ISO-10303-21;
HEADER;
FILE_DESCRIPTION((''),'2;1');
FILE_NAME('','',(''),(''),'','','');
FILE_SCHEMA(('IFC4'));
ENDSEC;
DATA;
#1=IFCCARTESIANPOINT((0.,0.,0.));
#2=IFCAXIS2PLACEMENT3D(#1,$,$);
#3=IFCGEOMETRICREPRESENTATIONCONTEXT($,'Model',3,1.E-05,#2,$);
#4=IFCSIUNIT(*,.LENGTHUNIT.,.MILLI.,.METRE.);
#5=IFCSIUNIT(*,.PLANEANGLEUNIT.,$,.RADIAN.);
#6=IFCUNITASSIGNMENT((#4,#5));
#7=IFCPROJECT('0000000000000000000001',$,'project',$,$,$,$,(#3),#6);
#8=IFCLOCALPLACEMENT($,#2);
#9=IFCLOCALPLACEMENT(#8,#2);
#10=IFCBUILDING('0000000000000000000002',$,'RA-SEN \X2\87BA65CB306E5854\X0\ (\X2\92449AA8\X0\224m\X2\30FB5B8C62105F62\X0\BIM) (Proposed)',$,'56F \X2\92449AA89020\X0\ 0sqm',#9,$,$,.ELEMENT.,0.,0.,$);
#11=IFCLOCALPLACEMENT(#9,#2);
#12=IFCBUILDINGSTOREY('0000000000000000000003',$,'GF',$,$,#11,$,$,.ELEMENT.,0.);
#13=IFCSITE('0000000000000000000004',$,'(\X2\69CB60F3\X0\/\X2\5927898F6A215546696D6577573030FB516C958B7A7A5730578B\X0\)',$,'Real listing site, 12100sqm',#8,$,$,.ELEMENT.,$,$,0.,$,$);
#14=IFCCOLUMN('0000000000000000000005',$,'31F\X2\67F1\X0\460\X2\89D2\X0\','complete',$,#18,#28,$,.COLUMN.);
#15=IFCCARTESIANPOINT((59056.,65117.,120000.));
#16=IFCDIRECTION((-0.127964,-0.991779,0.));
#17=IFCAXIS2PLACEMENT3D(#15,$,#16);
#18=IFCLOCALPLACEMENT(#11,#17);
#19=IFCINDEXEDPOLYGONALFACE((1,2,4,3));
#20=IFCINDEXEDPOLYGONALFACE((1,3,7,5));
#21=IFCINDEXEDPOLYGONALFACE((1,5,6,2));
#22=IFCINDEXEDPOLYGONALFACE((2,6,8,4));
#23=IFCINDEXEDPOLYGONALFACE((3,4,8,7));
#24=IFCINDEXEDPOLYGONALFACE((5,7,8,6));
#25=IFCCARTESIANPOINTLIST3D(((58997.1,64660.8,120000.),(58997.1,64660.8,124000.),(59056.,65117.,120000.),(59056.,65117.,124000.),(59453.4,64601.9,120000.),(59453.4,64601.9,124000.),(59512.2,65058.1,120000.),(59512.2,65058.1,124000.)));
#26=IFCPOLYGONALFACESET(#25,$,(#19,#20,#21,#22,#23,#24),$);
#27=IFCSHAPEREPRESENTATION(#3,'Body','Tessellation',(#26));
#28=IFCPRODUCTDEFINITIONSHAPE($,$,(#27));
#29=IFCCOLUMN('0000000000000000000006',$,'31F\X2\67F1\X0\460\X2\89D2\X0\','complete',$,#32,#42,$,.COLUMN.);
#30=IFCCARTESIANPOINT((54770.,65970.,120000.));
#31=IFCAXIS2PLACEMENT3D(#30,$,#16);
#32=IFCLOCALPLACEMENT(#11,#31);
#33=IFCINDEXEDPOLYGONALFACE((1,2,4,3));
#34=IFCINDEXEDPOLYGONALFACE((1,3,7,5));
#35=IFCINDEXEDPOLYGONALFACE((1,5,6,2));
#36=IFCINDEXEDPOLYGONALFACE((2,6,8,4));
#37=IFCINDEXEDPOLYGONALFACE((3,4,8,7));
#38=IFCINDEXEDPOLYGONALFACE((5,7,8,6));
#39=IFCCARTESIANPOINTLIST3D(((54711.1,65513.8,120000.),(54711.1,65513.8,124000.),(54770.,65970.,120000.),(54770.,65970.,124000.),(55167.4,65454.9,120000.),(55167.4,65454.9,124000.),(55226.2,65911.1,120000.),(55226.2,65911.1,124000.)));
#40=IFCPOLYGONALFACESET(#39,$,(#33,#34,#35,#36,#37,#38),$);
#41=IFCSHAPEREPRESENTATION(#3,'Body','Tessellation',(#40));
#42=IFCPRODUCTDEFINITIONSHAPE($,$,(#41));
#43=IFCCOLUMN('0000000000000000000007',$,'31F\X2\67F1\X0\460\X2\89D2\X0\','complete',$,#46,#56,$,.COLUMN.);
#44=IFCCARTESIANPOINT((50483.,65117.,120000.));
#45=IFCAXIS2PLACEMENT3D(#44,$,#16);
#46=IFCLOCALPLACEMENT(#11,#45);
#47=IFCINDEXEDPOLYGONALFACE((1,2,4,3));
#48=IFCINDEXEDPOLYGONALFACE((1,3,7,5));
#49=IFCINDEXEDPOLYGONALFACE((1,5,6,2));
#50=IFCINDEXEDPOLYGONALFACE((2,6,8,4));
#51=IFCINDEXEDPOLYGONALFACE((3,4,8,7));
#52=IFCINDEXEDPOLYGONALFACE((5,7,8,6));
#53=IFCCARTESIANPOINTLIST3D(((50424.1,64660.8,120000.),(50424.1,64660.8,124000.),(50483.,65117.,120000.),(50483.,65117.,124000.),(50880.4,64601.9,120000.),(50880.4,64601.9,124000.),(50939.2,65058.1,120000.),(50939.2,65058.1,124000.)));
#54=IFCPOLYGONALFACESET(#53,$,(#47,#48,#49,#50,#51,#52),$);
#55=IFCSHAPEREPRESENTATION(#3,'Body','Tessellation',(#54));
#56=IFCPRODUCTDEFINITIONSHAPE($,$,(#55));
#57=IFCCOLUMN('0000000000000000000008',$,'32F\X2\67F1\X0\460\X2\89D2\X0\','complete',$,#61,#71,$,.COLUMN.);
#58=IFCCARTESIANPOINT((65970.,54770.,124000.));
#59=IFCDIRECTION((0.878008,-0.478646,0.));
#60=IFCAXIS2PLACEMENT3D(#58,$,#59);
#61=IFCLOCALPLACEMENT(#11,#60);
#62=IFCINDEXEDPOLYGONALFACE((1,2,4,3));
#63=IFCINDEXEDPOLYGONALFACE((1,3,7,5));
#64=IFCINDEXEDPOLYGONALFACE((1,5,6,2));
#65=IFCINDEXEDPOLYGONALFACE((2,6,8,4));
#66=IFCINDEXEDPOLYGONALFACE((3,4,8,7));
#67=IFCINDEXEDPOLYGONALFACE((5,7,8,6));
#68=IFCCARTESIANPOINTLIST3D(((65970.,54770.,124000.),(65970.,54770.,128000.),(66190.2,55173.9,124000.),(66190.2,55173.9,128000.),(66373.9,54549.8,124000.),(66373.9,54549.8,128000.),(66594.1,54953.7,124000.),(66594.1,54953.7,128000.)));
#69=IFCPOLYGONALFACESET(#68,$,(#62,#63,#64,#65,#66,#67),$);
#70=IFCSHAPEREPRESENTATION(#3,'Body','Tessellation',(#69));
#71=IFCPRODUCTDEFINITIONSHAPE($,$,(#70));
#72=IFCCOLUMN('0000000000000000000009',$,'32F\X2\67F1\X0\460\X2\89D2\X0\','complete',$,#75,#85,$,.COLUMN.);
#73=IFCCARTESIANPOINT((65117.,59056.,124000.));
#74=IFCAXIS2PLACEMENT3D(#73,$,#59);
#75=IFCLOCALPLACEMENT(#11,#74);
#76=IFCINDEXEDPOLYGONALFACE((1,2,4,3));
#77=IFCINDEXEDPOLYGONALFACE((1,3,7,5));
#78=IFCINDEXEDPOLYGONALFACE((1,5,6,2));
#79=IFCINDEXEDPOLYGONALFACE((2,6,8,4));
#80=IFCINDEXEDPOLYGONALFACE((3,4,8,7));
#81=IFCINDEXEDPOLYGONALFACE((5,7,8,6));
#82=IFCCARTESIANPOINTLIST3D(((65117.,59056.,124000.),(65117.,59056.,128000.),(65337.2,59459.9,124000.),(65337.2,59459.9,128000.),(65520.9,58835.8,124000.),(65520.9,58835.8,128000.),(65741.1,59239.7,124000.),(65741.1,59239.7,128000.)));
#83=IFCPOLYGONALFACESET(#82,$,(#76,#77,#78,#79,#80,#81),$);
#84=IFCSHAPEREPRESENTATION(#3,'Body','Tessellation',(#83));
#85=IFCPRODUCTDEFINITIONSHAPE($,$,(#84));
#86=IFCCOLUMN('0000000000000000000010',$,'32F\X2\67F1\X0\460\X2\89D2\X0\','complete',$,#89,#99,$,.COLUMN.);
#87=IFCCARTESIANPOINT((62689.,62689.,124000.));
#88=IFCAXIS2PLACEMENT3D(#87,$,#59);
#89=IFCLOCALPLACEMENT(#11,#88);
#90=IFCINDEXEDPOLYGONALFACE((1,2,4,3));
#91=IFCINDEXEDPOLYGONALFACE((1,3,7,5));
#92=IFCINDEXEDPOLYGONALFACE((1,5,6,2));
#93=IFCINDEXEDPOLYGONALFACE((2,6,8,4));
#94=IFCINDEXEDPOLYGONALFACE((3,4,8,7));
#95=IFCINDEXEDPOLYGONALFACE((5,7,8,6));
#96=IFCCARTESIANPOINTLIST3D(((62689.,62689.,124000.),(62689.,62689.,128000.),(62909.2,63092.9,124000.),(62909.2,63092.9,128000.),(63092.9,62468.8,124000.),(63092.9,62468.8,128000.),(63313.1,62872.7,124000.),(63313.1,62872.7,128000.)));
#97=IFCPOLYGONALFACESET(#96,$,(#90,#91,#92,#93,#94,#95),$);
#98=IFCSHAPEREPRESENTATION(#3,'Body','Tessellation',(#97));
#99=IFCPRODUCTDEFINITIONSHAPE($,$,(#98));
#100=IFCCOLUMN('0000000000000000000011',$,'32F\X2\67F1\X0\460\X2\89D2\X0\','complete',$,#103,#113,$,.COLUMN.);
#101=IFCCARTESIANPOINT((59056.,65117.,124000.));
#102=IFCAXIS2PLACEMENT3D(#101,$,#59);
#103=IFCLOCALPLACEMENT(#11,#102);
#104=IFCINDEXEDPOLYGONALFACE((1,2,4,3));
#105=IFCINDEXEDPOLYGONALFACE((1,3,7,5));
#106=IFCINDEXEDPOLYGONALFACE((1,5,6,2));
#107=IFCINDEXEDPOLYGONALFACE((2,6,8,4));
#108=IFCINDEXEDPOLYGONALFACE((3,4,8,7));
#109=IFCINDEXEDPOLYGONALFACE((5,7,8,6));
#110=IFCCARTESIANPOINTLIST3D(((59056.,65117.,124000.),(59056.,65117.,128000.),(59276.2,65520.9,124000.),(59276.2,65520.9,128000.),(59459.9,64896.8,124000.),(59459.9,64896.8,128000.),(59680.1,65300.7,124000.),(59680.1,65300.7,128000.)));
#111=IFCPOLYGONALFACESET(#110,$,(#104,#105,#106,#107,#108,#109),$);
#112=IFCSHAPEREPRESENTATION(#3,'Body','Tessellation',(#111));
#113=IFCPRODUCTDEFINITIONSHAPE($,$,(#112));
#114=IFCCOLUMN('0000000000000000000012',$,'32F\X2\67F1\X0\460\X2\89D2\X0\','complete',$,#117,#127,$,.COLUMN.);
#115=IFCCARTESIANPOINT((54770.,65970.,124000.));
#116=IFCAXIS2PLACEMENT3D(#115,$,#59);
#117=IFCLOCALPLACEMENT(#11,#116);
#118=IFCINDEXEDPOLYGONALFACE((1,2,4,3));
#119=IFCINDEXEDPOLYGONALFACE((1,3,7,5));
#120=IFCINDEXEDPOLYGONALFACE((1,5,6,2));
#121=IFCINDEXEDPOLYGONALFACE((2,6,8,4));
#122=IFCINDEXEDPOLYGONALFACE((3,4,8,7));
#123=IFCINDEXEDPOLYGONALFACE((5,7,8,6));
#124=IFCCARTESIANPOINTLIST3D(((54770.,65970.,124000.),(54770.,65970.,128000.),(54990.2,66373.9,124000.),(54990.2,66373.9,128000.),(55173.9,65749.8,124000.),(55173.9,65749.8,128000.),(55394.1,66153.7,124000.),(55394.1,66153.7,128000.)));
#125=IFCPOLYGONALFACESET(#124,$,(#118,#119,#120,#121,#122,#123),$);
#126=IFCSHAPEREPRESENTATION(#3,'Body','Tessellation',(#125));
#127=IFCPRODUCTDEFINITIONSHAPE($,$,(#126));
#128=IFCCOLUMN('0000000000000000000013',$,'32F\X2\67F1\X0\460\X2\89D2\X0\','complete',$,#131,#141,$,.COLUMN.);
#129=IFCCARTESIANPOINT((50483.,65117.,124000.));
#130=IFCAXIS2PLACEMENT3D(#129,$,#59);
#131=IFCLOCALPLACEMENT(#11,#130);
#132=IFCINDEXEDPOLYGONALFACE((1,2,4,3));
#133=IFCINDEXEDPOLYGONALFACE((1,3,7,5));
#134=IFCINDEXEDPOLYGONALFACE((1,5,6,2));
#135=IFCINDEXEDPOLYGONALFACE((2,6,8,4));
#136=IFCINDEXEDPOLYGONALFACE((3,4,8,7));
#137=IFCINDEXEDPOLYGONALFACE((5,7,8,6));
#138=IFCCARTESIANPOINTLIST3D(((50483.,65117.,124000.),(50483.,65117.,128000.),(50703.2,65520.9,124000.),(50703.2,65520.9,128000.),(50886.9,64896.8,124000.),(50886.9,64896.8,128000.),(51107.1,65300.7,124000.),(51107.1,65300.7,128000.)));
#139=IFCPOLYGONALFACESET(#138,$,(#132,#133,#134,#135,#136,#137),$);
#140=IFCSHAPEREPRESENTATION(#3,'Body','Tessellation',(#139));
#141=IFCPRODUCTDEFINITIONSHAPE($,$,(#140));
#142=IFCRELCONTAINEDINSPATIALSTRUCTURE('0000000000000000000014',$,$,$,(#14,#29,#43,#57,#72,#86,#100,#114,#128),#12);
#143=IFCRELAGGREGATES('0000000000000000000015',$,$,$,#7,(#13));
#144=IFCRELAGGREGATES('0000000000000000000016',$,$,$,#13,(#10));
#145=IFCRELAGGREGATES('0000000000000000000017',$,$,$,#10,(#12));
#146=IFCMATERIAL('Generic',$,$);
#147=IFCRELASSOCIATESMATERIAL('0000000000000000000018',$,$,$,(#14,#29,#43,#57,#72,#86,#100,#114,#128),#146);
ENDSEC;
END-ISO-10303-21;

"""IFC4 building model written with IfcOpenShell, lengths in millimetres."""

from ifc_helpers import new_model, si_unit, frame, frame_2d, origin, place, context, project, spatial, rectangle, extrude, material, element, save


model = new_model("IFC4")

# Units and contexts
model_context = context("Model", 3, precision=1e-05, world=origin())
ifc_project = project(units=[si_unit("LENGTHUNIT", "METRE", prefix="MILLI"), si_unit("PLANEANGLEUNIT", "RADIAN")], contexts=[model_context])

# Site, building, storey
site_placement = place(None, origin())
site = spatial("IfcSite", under=ifc_project, at=site_placement, Name="(構想/大規模商業敷地・公開空地型)", ObjectType="Real listing site, 12100sqm", CompositionType="ELEMENT", RefElevation=0.0)
building_placement = place(site_placement, origin())
building = spatial("IfcBuilding", under=site, at=building_placement, Name="RA-SEN 螺旋の塔 (鉄骨224m・完成形BIM) (Proposed)", ObjectType="56F 鉄骨造 0sqm", CompositionType="ELEMENT", ElevationOfRefHeight=0.0, ElevationOfTerrain=0.0)
storey_placement = place(building_placement, origin())
storey = spatial("IfcBuildingStorey", under=building, at=storey_placement, Name="GF", CompositionType="ELEMENT", Elevation=0.0)

# Columns
ifc_material = material(Name="Generic")
column_1_placement = place(storey_placement, frame((59056.0, 65117.0, 120000.0), x_axis=(-0.127964, -0.991779, 0.0)))
element("IfcColumn", 1, at=column_1_placement, inside=storey, material=ifc_material, Name="31F柱460角", Description="complete", PredefinedType="COLUMN", context=model_context, shape_type="SweptSolid", body=[
    extrude(rectangle(XDim=460.0, YDim=460.0, at=frame_2d((230.0, 230.0))), frame((59056.0, 65117.0, 120000.0), x_axis=(-0.127964, -0.991779, 0.0)), (0.0, 0.0, 1.0), 4000.0),
])
column_2_placement = place(storey_placement, frame((54770.0, 65970.0, 120000.0), x_axis=(-0.127964, -0.991779, 0.0)))
element("IfcColumn", 2, at=column_2_placement, inside=storey, material=ifc_material, Name="31F柱460角", Description="complete", PredefinedType="COLUMN", context=model_context, shape_type="SweptSolid", body=[
    extrude(rectangle(XDim=460.0, YDim=460.0, at=frame_2d((230.0, 230.0))), frame((54770.0, 65970.0, 120000.0), x_axis=(-0.127964, -0.991779, 0.0)), (0.0, 0.0, 1.0), 4000.0),
])
column_3_placement = place(storey_placement, frame((50483.0, 65117.0, 120000.0), x_axis=(-0.127964, -0.991779, 0.0)))
element("IfcColumn", 3, at=column_3_placement, inside=storey, material=ifc_material, Name="31F柱460角", Description="complete", PredefinedType="COLUMN", context=model_context, shape_type="SweptSolid", body=[
    extrude(rectangle(XDim=460.0, YDim=460.0, at=frame_2d((230.0, 230.0))), frame((50483.0, 65117.0, 120000.0), x_axis=(-0.127964, -0.991779, 0.0)), (0.0, 0.0, 1.0), 4000.0),
])
column_4_placement = place(storey_placement, frame((65970.0, 54770.0, 124000.0), x_axis=(0.878008, -0.478646, 0.0)))
element("IfcColumn", 4, at=column_4_placement, inside=storey, material=ifc_material, Name="32F柱460角", Description="complete", PredefinedType="COLUMN", context=model_context, shape_type="SweptSolid", body=[
    extrude(rectangle(XDim=460.0, YDim=460.0, at=frame_2d((230.0, 230.0))), frame((65970.0, 54770.0, 124000.0), x_axis=(0.878008, -0.478646, 0.0)), (0.0, 0.0, 1.0), 4000.0),
])
column_5_placement = place(storey_placement, frame((65117.0, 59056.0, 124000.0), x_axis=(0.878008, -0.478646, 0.0)))
element("IfcColumn", 5, at=column_5_placement, inside=storey, material=ifc_material, Name="32F柱460角", Description="complete", PredefinedType="COLUMN", context=model_context, shape_type="SweptSolid", body=[
    extrude(rectangle(XDim=460.0, YDim=460.0, at=frame_2d((230.0, 230.0))), frame((65117.0, 59056.0, 124000.0), x_axis=(0.878008, -0.478646, 0.0)), (0.0, 0.0, 1.0), 4000.0),
])
column_6_placement = place(storey_placement, frame((62689.0, 62689.0, 124000.0), x_axis=(0.878008, -0.478646, 0.0)))
element("IfcColumn", 6, at=column_6_placement, inside=storey, material=ifc_material, Name="32F柱460角", Description="complete", PredefinedType="COLUMN", context=model_context, shape_type="SweptSolid", body=[
    extrude(rectangle(XDim=460.0, YDim=460.0, at=frame_2d((230.0, 230.0))), frame((62689.0, 62689.0, 124000.0), x_axis=(0.878008, -0.478646, 0.0)), (0.0, 0.0, 1.0), 4000.0),
])
column_7_placement = place(storey_placement, frame((59056.0, 65117.0, 124000.0), x_axis=(0.878008, -0.478646, 0.0)))
element("IfcColumn", 7, at=column_7_placement, inside=storey, material=ifc_material, Name="32F柱460角", Description="complete", PredefinedType="COLUMN", context=model_context, shape_type="SweptSolid", body=[
    extrude(rectangle(XDim=460.0, YDim=460.0, at=frame_2d((230.0, 230.0))), frame((59056.0, 65117.0, 124000.0), x_axis=(0.878008, -0.478646, 0.0)), (0.0, 0.0, 1.0), 4000.0),
])
column_8_placement = place(storey_placement, frame((54770.0, 65970.0, 124000.0), x_axis=(0.878008, -0.478646, 0.0)))
element("IfcColumn", 8, at=column_8_placement, inside=storey, material=ifc_material, Name="32F柱460角", Description="complete", PredefinedType="COLUMN", context=model_context, shape_type="SweptSolid", body=[
    extrude(rectangle(XDim=460.0, YDim=460.0, at=frame_2d((230.0, 230.0))), frame((54770.0, 65970.0, 124000.0), x_axis=(0.878008, -0.478646, 0.0)), (0.0, 0.0, 1.0), 4000.0),
])
column_9_placement = place(storey_placement, frame((50483.0, 65117.0, 124000.0), x_axis=(0.878008, -0.478646, 0.0)))
element("IfcColumn", 9, at=column_9_placement, inside=storey, material=ifc_material, Name="32F柱460角", Description="complete", PredefinedType="COLUMN", context=model_context, shape_type="SweptSolid", body=[
    extrude(rectangle(XDim=460.0, YDim=460.0, at=frame_2d((230.0, 230.0))), frame((50483.0, 65117.0, 124000.0), x_axis=(0.878008, -0.478646, 0.0)), (0.0, 0.0, 1.0), 4000.0),
])

save(model, "model.ifc")
